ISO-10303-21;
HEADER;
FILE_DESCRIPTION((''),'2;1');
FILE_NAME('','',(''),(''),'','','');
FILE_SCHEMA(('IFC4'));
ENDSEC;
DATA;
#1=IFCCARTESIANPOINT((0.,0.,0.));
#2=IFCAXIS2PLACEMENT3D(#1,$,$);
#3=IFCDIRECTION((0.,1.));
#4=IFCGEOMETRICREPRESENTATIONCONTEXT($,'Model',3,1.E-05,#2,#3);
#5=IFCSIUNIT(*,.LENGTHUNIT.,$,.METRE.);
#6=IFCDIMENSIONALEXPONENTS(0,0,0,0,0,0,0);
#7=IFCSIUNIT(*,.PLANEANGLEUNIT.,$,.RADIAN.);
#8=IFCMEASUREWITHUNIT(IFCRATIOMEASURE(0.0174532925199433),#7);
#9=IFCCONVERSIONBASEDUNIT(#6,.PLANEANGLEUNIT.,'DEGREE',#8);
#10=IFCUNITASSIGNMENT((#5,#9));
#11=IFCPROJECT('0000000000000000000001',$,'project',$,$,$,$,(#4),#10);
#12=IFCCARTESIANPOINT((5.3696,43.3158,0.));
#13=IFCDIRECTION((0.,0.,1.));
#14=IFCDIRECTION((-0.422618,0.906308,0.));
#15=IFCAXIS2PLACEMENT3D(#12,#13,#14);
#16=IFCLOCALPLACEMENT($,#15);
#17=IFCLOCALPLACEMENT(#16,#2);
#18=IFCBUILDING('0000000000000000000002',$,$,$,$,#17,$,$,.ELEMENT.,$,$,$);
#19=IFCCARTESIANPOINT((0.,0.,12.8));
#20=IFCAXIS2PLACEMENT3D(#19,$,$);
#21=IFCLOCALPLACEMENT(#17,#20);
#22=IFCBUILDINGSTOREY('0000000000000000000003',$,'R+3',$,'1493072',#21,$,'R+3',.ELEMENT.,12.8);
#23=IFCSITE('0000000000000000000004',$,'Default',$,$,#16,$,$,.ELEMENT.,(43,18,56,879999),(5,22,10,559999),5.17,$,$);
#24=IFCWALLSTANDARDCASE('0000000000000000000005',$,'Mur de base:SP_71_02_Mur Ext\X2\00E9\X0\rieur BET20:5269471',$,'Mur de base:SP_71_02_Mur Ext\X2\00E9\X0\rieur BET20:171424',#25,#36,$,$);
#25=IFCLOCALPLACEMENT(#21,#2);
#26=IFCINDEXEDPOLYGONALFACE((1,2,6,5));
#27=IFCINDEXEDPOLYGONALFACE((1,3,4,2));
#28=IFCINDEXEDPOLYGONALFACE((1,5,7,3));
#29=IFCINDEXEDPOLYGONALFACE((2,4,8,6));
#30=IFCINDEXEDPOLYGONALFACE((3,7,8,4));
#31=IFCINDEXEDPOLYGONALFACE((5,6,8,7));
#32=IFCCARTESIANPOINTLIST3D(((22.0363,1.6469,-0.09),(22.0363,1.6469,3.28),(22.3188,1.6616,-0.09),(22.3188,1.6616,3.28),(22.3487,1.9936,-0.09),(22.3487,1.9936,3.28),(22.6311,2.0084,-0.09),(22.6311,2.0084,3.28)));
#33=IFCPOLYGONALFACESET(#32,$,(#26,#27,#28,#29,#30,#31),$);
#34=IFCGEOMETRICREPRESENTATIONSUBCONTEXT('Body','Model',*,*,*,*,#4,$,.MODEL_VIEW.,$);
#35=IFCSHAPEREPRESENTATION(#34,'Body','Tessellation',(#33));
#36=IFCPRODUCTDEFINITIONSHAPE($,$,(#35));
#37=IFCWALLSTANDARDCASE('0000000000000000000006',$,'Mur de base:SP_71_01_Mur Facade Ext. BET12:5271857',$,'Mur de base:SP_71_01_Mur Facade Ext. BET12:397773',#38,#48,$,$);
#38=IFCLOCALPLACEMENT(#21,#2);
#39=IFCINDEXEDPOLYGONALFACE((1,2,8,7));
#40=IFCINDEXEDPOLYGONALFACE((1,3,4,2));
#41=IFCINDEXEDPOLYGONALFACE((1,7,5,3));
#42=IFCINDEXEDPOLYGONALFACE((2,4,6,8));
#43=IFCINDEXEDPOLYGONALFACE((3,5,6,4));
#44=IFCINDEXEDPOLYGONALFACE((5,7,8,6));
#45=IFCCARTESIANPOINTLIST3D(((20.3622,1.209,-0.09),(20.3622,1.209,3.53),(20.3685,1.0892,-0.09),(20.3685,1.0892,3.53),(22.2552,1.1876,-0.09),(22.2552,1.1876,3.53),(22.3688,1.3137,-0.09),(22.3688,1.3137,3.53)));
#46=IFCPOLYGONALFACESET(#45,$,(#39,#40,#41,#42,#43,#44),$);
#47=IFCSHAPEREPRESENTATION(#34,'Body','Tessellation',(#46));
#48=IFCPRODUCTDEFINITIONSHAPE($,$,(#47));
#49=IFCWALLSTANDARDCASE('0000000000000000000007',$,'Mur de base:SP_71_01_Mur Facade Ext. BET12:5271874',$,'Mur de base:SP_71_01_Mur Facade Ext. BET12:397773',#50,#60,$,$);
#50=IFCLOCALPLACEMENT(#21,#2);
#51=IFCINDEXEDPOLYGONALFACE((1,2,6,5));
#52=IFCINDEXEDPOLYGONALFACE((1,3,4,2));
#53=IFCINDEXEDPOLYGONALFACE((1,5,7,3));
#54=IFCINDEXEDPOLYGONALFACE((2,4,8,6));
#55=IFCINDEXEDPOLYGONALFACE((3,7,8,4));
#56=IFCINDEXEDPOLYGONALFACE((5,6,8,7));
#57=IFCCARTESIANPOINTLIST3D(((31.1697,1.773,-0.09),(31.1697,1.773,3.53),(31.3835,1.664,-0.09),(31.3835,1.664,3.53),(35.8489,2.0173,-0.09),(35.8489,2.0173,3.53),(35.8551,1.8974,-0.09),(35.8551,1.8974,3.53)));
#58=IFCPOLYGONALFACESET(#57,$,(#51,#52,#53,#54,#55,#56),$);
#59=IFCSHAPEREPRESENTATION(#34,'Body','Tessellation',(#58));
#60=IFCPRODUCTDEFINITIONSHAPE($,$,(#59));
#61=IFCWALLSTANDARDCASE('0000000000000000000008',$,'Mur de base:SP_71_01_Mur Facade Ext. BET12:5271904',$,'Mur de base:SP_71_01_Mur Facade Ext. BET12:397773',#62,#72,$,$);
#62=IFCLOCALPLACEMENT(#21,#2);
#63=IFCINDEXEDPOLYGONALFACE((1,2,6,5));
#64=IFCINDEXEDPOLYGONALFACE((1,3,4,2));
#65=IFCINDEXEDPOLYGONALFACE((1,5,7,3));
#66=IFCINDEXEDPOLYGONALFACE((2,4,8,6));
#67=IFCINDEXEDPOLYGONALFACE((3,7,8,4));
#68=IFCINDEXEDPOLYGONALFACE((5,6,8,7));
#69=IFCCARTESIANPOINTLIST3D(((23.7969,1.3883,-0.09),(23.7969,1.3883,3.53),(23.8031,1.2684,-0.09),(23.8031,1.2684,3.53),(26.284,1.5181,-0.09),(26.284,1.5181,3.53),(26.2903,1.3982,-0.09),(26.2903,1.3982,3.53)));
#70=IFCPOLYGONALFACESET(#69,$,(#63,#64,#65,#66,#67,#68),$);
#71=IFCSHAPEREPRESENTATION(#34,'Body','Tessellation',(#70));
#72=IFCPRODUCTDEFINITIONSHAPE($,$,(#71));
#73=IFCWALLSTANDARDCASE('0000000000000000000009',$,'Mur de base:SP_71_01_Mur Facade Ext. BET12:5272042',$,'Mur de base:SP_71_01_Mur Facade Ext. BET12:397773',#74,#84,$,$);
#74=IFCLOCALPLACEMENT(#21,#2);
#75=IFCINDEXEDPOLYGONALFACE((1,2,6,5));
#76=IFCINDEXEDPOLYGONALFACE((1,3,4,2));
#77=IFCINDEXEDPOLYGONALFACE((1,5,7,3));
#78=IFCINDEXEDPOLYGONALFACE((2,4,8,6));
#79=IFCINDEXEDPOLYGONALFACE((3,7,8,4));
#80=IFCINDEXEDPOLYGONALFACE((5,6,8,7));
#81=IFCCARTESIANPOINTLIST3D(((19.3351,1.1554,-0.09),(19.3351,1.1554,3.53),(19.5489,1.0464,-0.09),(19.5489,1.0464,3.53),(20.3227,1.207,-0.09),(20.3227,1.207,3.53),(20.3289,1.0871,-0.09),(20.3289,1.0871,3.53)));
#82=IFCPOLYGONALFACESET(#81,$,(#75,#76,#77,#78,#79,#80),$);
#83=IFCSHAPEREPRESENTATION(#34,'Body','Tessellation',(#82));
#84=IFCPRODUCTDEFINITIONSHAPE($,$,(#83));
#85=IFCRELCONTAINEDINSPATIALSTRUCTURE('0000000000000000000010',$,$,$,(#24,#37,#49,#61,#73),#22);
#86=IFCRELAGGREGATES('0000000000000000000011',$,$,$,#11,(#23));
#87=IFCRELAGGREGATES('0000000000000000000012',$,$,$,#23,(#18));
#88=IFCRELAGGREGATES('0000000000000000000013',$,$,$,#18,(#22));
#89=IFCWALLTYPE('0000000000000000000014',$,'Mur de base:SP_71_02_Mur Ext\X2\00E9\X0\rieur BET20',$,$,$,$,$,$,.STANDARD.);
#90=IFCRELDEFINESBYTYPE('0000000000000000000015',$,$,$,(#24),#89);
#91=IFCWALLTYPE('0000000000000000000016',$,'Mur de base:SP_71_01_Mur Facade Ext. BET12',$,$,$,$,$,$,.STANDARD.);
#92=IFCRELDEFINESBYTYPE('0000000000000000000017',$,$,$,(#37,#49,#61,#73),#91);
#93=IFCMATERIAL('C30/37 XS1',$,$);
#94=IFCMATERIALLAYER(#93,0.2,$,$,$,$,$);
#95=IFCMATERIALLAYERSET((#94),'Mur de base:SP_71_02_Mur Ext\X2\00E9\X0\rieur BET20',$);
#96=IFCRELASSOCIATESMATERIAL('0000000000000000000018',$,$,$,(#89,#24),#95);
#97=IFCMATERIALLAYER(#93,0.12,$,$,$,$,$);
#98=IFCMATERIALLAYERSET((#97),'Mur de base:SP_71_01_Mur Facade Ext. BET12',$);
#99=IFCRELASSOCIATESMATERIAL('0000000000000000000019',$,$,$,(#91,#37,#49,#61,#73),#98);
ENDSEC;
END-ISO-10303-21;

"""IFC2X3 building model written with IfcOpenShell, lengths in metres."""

from ifc_helpers import new_model, entity, si_unit, converted_unit, direction, frame, frame_2d, origin, place, context, subcontext, project, spatial, polyline, rectangle, outline, extrude, clip, halfspace, material, layer, layer_set, layer_usage, type_object, element, save


model = new_model("IFC2X3")

# Units and contexts
model_context = context("Model", 3, precision=1e-05, world=origin(), true_north=direction((0.0, 1.0)))
body_context = subcontext(model_context, "Body", "Model", "MODEL_VIEW")
ifc_project = project(units=[si_unit("LENGTHUNIT", "METRE"), converted_unit("PLANEANGLEUNIT", "DEGREE", entity("IfcRatioMeasure", 0.0174532925199433), si_unit("PLANEANGLEUNIT", "RADIAN"), dimensions=[0, 0, 0, 0, 0, 0, 0])], contexts=[model_context])

# Site, building, storey
site_placement = place(None, frame((5.3696, 43.3158, 0.0), z_axis=(0.0, 0.0, 1.0), x_axis=(-0.422618, 0.906308, 0.0)))
site = spatial("IfcSite", under=ifc_project, at=site_placement, Name="Default", CompositionType="ELEMENT", RefLatitude=(43, 18, 56, 879999), RefLongitude=(5, 22, 10, 559999), RefElevation=5.17)
building_placement = place(site_placement, origin())
building = spatial("IfcBuilding", under=site, at=building_placement, CompositionType="ELEMENT")
storey_placement = place(building_placement, frame((0.0, 0.0, 12.8)))
storey = spatial("IfcBuildingStorey", under=building, at=storey_placement, Name="R+3", ObjectType="1493072", LongName="R+3", CompositionType="ELEMENT", Elevation=12.8)

# Shared definitions
ifc_material = material(Name="C30/37 XS1")

# Shared definitions
ifc_layer_1 = layer(ifc_material, 0.2)
ifc_layer_set_1 = layer_set([ifc_layer_1], Name="Mur de base:SP_71_02_Mur Extérieur BET20")
wall_type_1 = type_object("IfcWallType", Name="Mur de base:SP_71_02_Mur Extérieur BET20", PredefinedType="STANDARD", material=ifc_layer_set_1)

# Wall
ifc_layer_usage_1 = layer_usage(ifc_layer_set_1, "AXIS2", "NEGATIVE", 0.1)
wall_1_placement = place(storey_placement, frame((22.5568, 2.0753, -0.09), z_axis=(0.0, 0.0, 1.0), x_axis=(-0.669291, -0.743, 0.0)))
element("IfcWallStandardCase", 1, at=wall_1_placement, inside=storey, type_object=wall_type_1, material=ifc_layer_usage_1, Name="Mur de base:SP_71_02_Mur Extérieur BET20:5269471", ObjectType="Mur de base:SP_71_02_Mur Extérieur BET20:171424", context=body_context, shape_type="SweptSolid", body=[
    extrude(outline(polyline([(0.6667, -0.1), (0.4667, 0.1), (0.0, 0.1), (0.2, -0.1), (0.6667, -0.1)])), origin(), (0.0, 0.0, 1.0), 3.37),
])

# Shared definitions
ifc_layer_2 = layer(ifc_material, 0.12)
ifc_layer_set_2 = layer_set([ifc_layer_2], Name="Mur de base:SP_71_01_Mur Facade Ext. BET12")
wall_type_2 = type_object("IfcWallType", Name="Mur de base:SP_71_01_Mur Facade Ext. BET12", PredefinedType="STANDARD", material=ifc_layer_set_2)

# Walls
ifc_layer_usage_2 = layer_usage(ifc_layer_set_2, "AXIS2", "NEGATIVE", 0.06)
wall_2_placement = place(storey_placement, frame((22.3719, 1.2538, -0.09), z_axis=(0.0, 0.0, 1.0), x_axis=(-0.998641, -0.05212, 0.0)))
element("IfcWallStandardCase", 2, at=wall_2_placement, inside=storey, type_object=wall_type_2, material=ifc_layer_usage_2, Name="Mur de base:SP_71_01_Mur Facade Ext. BET12:5271857", ObjectType="Mur de base:SP_71_01_Mur Facade Ext. BET12:397773", context=body_context, shape_type="Clipping", body=[
    clip(extrude(outline(polyline([(2.0093, -0.06), (2.0093, 0.06), (0.12, 0.06), (0.0, -0.06), (0.1697, -0.06), (2.0093, -0.06)])), origin(), (0.0, 0.0, 1.0), 3.62), halfspace(frame((0.0, 0.0, -0.09)), True)),
])
ifc_layer_usage_3 = layer_usage(ifc_layer_set_2, "AXIS2", "NEGATIVE", 0.06)
wall_3_placement = place(storey_placement, frame((35.852, 1.9573, -0.09), z_axis=(0.0, 0.0, 1.0), x_axis=(-0.998641, -0.05212, 0.0)))
element("IfcWallStandardCase", 3, at=wall_3_placement, inside=storey, type_object=wall_type_2, material=ifc_layer_usage_3, Name="Mur de base:SP_71_01_Mur Facade Ext. BET12:5271874", ObjectType="Mur de base:SP_71_01_Mur Facade Ext. BET12:397773", context=body_context, shape_type="Clipping", body=[
    clip(extrude(outline(polyline([(4.6856, -0.06), (4.4777, 0.06), (3.1305, 0.06), (1.1228, 0.06), (0.0, 0.06), (0.0, -0.06), (0.12, -0.06), (1.1228, -0.06), (3.3383, -0.06), (4.4456, -0.06), (4.6856, -0.06)])), origin(), (0.0, 0.0, 1.0), 3.62), halfspace(frame((0.0, 0.0, -0.09)), True)),
])
ifc_layer_usage_4 = layer_usage(ifc_layer_set_2, "AXIS2", "NEGATIVE", 0.06)
wall_4_placement = place(storey_placement, frame((26.2871, 1.4581, -0.09), z_axis=(0.0, 0.0, 1.0), x_axis=(-0.998641, -0.05212, 0.0)))
element("IfcWallStandardCase", 4, at=wall_4_placement, inside=storey, type_object=wall_type_2, material=ifc_layer_usage_4, Name="Mur de base:SP_71_01_Mur Facade Ext. BET12:5271904", ObjectType="Mur de base:SP_71_01_Mur Facade Ext. BET12:397773", context=body_context, shape_type="Clipping", body=[
    clip(extrude(rectangle(XDim=2.4905, YDim=0.12, at=frame_2d((1.2453, 0.0), x_axis=(-1.0, 0.0))), origin(), (0.0, 0.0, 1.0), 3.62), halfspace(frame((0.0, 0.0, -0.09)), True)),
])
ifc_layer_usage_5 = layer_usage(ifc_layer_set_2, "AXIS2", "NEGATIVE", 0.06)
wall_5_placement = place(storey_placement, frame((20.3258, 1.1471, -0.09), z_axis=(0.0, 0.0, 1.0), x_axis=(-0.998641, -0.05212, 0.0)))
element("IfcWallStandardCase", 5, at=wall_5_placement, inside=storey, type_object=wall_type_2, material=ifc_layer_usage_5, Name="Mur de base:SP_71_01_Mur Facade Ext. BET12:5272042", ObjectType="Mur de base:SP_71_01_Mur Facade Ext. BET12:397773", context=body_context, shape_type="Clipping", body=[
    clip(extrude(outline(polyline([(0.9889, -0.06), (0.7811, 0.06), (0.7804, 0.06), (0.0, 0.06), (0.0, -0.06), (0.7489, -0.06), (0.9882, -0.06), (0.9889, -0.06)])), origin(), (0.0, 0.0, 1.0), 3.62), halfspace(frame((0.0, 0.0, -0.09)), True)),
])

save(model, "model.ifc")
